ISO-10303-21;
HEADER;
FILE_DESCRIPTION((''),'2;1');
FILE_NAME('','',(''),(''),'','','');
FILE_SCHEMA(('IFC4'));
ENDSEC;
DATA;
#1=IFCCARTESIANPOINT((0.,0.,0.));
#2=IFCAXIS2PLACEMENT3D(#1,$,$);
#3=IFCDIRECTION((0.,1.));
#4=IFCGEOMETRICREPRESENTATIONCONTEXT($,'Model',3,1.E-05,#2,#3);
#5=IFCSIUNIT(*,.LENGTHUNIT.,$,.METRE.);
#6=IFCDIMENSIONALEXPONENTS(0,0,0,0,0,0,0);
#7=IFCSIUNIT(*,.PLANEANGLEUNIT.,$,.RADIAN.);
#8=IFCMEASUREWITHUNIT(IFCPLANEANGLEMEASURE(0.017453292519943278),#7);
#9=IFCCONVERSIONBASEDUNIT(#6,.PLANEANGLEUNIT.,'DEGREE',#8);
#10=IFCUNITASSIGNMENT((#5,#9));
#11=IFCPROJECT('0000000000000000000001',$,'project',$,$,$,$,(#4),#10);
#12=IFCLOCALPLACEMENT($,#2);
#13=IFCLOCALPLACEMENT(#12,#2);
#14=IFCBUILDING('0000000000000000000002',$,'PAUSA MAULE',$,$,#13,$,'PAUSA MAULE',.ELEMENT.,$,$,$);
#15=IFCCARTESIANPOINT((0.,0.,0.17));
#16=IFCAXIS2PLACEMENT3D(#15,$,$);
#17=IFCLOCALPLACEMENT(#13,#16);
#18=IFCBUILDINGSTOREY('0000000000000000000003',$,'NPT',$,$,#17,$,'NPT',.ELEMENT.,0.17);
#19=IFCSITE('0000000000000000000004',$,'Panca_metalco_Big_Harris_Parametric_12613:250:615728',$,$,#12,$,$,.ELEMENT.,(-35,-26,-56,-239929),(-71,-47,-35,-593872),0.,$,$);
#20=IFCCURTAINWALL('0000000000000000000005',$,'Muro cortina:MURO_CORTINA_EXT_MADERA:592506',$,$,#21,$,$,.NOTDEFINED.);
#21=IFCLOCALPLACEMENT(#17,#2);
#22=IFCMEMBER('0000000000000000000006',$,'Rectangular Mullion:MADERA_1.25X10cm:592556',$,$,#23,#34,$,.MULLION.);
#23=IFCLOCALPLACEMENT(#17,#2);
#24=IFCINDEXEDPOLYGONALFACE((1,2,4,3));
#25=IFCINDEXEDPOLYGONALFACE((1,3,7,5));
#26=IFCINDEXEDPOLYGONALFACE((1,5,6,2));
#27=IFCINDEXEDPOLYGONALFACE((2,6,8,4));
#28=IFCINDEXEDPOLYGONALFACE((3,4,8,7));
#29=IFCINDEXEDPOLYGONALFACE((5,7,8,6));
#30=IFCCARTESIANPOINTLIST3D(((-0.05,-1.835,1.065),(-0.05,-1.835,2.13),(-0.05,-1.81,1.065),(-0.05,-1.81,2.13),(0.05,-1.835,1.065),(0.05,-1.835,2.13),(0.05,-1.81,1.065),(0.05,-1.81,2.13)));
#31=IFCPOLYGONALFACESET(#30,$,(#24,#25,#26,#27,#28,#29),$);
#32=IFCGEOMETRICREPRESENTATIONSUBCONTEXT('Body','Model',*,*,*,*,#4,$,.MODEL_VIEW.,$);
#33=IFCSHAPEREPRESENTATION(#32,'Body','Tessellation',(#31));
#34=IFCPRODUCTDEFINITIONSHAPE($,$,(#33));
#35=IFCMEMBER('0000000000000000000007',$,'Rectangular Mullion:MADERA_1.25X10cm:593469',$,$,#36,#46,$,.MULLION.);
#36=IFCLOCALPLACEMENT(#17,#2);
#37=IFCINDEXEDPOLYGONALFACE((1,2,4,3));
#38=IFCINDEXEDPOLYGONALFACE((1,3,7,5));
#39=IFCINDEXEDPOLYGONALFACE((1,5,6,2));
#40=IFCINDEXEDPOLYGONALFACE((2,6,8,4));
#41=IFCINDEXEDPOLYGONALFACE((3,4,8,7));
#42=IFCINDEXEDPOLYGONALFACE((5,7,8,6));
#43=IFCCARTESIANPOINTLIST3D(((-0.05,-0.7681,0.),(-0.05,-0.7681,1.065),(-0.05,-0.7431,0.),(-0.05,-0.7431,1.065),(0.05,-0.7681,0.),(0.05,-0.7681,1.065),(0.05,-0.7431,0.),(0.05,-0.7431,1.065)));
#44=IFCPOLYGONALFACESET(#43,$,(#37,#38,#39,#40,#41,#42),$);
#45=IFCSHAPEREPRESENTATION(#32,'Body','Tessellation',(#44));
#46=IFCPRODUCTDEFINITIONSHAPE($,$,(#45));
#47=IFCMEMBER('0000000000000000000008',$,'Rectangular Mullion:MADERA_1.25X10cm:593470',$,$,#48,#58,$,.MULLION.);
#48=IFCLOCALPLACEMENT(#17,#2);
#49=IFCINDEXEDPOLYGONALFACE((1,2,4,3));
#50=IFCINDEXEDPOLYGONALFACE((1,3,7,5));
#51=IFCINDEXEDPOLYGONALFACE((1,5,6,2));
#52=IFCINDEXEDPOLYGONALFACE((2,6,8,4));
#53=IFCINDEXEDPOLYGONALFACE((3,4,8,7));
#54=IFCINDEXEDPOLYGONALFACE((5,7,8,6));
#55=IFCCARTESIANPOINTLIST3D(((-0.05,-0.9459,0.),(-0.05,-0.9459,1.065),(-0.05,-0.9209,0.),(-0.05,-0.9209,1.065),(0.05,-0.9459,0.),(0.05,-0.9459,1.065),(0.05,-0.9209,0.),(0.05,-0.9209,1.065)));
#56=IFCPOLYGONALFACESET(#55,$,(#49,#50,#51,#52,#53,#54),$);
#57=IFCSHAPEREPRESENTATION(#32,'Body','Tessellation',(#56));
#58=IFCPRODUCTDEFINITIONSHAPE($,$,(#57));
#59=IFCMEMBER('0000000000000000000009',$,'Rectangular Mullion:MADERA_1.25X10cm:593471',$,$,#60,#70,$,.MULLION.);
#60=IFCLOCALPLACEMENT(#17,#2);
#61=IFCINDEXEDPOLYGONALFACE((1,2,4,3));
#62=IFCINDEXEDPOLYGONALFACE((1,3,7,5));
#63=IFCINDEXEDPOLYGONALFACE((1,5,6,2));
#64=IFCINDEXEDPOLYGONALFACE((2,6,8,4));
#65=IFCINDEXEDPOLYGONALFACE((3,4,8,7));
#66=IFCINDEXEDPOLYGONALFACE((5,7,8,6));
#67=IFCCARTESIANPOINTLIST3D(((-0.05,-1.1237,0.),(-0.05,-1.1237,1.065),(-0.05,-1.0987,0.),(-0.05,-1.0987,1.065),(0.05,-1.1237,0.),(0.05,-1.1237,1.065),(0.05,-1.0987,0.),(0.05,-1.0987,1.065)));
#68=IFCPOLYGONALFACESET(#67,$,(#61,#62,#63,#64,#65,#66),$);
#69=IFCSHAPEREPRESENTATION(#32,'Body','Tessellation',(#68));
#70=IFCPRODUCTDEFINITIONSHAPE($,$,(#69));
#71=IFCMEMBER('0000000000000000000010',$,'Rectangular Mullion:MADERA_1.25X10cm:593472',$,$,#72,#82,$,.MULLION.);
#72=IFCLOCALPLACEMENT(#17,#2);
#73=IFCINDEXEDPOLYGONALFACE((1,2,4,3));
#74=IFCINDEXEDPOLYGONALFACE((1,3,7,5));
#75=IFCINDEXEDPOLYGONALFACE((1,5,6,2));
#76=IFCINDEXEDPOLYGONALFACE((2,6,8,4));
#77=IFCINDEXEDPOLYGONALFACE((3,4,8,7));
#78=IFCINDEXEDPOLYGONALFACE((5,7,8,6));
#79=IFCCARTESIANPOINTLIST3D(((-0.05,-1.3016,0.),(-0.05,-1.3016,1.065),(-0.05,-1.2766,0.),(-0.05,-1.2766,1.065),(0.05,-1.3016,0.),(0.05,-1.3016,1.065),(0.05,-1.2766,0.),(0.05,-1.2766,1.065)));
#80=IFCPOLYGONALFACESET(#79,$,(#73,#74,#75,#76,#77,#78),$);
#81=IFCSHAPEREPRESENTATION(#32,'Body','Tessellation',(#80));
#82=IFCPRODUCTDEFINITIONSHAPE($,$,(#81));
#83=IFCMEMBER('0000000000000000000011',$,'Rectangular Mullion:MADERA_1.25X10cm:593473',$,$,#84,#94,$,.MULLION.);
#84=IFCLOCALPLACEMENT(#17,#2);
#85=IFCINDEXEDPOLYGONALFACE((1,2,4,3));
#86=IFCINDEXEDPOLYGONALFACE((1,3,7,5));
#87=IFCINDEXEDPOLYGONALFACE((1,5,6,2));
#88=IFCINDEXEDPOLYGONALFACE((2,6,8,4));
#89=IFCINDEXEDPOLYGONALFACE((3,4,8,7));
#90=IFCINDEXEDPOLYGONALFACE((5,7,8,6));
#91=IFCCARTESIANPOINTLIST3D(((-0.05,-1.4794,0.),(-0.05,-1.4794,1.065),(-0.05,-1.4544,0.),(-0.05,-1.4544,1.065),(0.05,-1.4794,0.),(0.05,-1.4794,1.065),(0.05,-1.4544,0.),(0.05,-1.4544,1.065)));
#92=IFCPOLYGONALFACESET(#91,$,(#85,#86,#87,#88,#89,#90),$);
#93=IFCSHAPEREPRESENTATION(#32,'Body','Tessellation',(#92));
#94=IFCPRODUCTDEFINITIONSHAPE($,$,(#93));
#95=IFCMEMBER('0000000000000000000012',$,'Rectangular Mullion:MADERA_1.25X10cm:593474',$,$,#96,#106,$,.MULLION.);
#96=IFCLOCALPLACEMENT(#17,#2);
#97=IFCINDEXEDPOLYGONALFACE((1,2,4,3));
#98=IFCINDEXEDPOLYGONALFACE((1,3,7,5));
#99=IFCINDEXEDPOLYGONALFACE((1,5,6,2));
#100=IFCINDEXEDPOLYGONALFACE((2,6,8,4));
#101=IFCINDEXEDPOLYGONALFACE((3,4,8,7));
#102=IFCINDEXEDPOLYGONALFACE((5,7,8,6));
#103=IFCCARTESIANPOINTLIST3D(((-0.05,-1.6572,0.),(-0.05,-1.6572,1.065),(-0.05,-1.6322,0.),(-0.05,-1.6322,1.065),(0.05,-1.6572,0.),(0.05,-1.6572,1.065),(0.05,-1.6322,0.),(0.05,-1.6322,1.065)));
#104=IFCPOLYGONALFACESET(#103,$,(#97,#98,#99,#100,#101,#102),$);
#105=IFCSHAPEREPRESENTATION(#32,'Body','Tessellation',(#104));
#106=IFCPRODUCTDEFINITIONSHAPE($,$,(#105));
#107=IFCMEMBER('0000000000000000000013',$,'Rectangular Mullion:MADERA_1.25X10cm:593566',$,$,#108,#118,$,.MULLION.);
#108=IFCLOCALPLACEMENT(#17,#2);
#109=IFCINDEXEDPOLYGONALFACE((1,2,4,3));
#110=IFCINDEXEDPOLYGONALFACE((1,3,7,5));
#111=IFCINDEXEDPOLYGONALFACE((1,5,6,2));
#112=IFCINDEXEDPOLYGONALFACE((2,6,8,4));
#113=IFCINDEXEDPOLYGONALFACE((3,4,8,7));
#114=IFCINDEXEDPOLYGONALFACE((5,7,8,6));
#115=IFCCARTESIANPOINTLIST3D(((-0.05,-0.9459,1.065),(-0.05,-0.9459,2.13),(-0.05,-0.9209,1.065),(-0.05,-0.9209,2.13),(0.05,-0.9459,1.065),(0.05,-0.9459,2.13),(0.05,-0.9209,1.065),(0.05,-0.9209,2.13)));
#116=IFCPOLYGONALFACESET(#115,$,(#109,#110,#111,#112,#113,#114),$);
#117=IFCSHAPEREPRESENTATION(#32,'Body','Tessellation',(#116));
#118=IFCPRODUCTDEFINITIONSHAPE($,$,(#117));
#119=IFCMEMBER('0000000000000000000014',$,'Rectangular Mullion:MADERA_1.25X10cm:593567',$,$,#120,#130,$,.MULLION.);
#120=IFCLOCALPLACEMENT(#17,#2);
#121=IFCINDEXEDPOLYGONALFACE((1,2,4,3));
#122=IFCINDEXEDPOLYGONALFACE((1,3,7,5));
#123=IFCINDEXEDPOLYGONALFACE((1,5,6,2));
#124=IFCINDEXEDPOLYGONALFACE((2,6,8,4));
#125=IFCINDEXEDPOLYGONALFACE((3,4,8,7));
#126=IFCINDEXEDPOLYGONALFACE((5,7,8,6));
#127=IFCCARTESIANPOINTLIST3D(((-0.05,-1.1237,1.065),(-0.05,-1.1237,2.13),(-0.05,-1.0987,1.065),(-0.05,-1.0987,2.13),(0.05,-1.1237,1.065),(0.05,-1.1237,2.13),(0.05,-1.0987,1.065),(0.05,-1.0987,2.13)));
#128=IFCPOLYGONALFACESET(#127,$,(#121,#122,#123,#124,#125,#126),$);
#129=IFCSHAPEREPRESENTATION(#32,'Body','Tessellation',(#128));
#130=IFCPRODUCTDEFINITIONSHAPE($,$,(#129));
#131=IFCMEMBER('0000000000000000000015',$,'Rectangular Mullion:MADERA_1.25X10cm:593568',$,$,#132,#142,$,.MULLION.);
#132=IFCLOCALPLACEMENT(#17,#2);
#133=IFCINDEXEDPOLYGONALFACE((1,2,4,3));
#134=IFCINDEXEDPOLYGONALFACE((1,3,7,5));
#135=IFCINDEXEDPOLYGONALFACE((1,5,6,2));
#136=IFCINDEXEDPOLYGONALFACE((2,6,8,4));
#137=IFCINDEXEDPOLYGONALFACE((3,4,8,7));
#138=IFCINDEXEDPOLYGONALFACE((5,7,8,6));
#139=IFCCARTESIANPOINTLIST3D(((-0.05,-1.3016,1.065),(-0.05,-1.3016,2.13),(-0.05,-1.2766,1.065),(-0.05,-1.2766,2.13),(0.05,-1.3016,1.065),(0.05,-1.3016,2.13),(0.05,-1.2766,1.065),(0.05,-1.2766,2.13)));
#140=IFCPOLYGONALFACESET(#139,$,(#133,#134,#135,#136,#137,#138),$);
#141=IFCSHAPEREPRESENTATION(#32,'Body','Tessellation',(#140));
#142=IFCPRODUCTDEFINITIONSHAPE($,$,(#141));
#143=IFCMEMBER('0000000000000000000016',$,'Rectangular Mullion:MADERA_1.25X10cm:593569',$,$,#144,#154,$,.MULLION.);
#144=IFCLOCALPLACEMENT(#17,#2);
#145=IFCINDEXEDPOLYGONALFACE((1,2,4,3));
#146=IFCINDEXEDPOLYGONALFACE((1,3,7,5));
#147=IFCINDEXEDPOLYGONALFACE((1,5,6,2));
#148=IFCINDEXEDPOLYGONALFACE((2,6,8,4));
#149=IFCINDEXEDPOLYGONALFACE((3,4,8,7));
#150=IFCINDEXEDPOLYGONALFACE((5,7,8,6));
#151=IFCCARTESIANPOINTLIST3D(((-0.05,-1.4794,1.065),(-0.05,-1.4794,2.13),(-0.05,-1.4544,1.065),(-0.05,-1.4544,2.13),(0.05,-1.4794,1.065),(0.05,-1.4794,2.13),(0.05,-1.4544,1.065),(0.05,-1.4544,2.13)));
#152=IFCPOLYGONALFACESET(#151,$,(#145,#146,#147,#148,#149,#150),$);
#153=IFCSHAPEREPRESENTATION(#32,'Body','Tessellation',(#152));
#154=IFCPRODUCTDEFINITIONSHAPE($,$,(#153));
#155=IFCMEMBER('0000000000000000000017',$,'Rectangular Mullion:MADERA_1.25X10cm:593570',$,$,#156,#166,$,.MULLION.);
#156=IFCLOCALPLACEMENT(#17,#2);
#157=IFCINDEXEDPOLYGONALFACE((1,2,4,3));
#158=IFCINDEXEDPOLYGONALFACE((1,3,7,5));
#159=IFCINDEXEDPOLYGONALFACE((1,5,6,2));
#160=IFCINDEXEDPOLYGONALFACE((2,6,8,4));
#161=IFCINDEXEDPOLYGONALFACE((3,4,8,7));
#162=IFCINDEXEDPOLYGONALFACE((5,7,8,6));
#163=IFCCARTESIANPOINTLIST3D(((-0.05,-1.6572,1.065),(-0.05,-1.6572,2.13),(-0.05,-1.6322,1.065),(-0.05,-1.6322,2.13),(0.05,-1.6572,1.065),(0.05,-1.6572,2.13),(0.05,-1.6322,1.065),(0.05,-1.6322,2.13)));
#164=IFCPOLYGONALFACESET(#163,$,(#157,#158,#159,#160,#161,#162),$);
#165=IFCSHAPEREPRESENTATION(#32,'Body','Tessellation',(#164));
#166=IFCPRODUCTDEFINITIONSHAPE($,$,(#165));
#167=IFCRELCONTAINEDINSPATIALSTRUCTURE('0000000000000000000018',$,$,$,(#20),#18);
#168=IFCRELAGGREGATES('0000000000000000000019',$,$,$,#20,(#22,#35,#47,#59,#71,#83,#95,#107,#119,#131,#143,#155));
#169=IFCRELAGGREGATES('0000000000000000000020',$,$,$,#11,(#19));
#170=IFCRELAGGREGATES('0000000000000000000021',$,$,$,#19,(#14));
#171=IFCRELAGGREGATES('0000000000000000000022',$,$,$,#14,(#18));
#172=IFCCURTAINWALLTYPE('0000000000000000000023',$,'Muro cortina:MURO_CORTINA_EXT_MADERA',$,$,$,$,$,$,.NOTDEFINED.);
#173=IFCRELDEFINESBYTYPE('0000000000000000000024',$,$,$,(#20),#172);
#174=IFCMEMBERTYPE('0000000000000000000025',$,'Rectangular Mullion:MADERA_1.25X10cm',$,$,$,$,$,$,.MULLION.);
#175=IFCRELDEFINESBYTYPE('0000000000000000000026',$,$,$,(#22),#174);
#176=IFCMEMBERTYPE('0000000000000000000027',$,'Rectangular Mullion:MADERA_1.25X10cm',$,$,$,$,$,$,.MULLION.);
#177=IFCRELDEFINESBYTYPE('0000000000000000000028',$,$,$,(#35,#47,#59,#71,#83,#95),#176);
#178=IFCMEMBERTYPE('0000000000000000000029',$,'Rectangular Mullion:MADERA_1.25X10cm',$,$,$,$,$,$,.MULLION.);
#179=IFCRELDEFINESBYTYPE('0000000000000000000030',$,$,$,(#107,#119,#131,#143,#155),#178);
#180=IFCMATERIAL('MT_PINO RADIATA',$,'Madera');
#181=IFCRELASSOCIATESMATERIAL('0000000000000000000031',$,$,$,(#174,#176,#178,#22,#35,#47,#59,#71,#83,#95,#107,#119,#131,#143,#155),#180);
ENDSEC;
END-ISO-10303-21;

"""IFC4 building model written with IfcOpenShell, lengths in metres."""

from ifc_helpers import new_model, entity, si_unit, converted_unit, direction, frame, frame_2d, origin, origin_2d_with_axis, place, context, subcontext, project, spatial, rectangle, extrude, source, transform, mapped, material, material_profile, profile_set, profile_usage, type_object, type_shapes, element, aggregate, save


model = new_model("IFC4")

# Units and contexts
model_context = context("Model", 3, precision=1e-05, world=origin(), true_north=direction((0.0, 1.0)))
body_context = subcontext(model_context, "Body", "Model", "MODEL_VIEW")
ifc_project = project(units=[si_unit("LENGTHUNIT", "METRE"), converted_unit("PLANEANGLEUNIT", "DEGREE", entity("IfcPlaneAngleMeasure", 0.017453292519943278), si_unit("PLANEANGLEUNIT", "RADIAN"), dimensions=[0, 0, 0, 0, 0, 0, 0])], contexts=[model_context])

# Site, building, storey
site_placement = place(None, origin())
site = spatial("IfcSite", under=ifc_project, at=site_placement, Name="Panca_metalco_Big_Harris_Parametric_12613:250:615728", CompositionType="ELEMENT", RefLatitude=(-35, -26, -56, -239929), RefLongitude=(-71, -47, -35, -593872), RefElevation=0.0)
building_placement = place(site_placement, origin())
building = spatial("IfcBuilding", under=site, at=building_placement, Name="PAUSA MAULE", LongName="PAUSA MAULE", CompositionType="ELEMENT")
storey_placement = place(building_placement, frame((0.0, 0.0, 0.17)))
storey = spatial("IfcBuildingStorey", under=building, at=storey_placement, Name="NPT", LongName="NPT", CompositionType="ELEMENT", Elevation=0.17)

# Curtain wall, members
curtain_wall_type = type_object("IfcCurtainWallType", Name="Muro cortina:MURO_CORTINA_EXT_MADERA", PredefinedType="NOTDEFINED")
curtain_wall_placement = place(storey_placement, frame((0.0, 0.0, -0.17)))
curtain_wall = element("IfcCurtainWall", 1, at=curtain_wall_placement, inside=storey, type_object=curtain_wall_type, Name="Muro cortina:MURO_CORTINA_EXT_MADERA:592506", PredefinedType="NOTDEFINED")
ifc_material = material(Name="MT_PINO RADIATA", Category="Madera")
ifc_material_profile = material_profile(ifc_material, rectangle(XDim=0.025, YDim=0.1, at=frame_2d((0.0, 0.0), x_axis=(1.0, 0.0))), Name="MADERA_1.25X10cm")
ifc_profile_set = profile_set([ifc_material_profile], Name="MADERA_1.25X10cm")
ifc_profile_usage = profile_usage(ifc_profile_set)
member_type_1 = type_object("IfcMemberType", Name="Rectangular Mullion:MADERA_1.25X10cm", PredefinedType="MULLION", material=ifc_profile_set)
shared_shape_1 = source(origin(), body_context, "Body", "SweptSolid", [
    extrude(rectangle(XDim=0.025, YDim=0.1, at=origin_2d_with_axis()), frame((-0.0125, 0.0, -1.065), z_axis=(0.0, 0.0, 1.0), x_axis=(-1.0, 0.0, 0.0)), (0.0, 0.0, 1.0), 1.065),
])
type_shapes(member_type_1, [shared_shape_1])
member_1_placement = place(curtain_wall_placement, frame((0.0, -1.835, 1.235), z_axis=(0.0, 0.0, -1.0), x_axis=(0.0, -1.0, 0.0)))
member_1 = element("IfcMember", 2, at=member_1_placement, type_object=member_type_1, material=ifc_profile_usage, Name="Rectangular Mullion:MADERA_1.25X10cm:592556", PredefinedType="MULLION", context=body_context, shape_type="MappedRepresentation", body=[
    mapped(shared_shape_1, transform((0.0, 0.0, 0.0), scale=1.0)),
])
member_type_2 = type_object("IfcMemberType", Name="Rectangular Mullion:MADERA_1.25X10cm", PredefinedType="MULLION", material=ifc_profile_set)
shared_shape_2 = source(origin(), body_context, "Body", "SweptSolid", [
    extrude(rectangle(XDim=0.025, YDim=0.1, at=frame_2d((0.0, 0.0), x_axis=(1.0, 0.0))), frame((0.0, 0.0, -1.065), z_axis=(0.0, 0.0, 1.0), x_axis=(-1.0, 0.0, 0.0)), (0.0, 0.0, 1.0), 1.065),
])
type_shapes(member_type_2, [shared_shape_2])
member_2_placement = place(curtain_wall_placement, frame((0.0, -0.7556, 0.17), z_axis=(0.0, 0.0, -1.0), x_axis=(0.0, -1.0, 0.0)))
member_2 = element("IfcMember", 3, at=member_2_placement, type_object=member_type_2, material=ifc_profile_usage, Name="Rectangular Mullion:MADERA_1.25X10cm:593469", PredefinedType="MULLION", context=body_context, shape_type="MappedRepresentation", body=[
    mapped(shared_shape_2, transform((0.0, 0.0, 0.0), scale=1.0)),
])
member_3_placement = place(curtain_wall_placement, frame((0.0, -0.9334, 0.17), z_axis=(0.0, 0.0, -1.0), x_axis=(0.0, -1.0, 0.0)))
member_3 = element("IfcMember", 4, at=member_3_placement, type_object=member_type_2, material=ifc_profile_usage, Name="Rectangular Mullion:MADERA_1.25X10cm:593470", PredefinedType="MULLION", context=body_context, shape_type="MappedRepresentation", body=[
    mapped(shared_shape_2, transform((0.0, 0.0, 0.0), scale=1.0)),
])
member_4_placement = place(curtain_wall_placement, frame((0.0, -1.1112, 0.17), z_axis=(0.0, 0.0, -1.0), x_axis=(0.0, -1.0, 0.0)))
member_4 = element("IfcMember", 5, at=member_4_placement, type_object=member_type_2, material=ifc_profile_usage, Name="Rectangular Mullion:MADERA_1.25X10cm:593471", PredefinedType="MULLION", context=body_context, shape_type="MappedRepresentation", body=[
    mapped(shared_shape_2, transform((0.0, 0.0, 0.0), scale=1.0)),
])
member_5_placement = place(curtain_wall_placement, frame((0.0, -1.2891, 0.17), z_axis=(0.0, 0.0, -1.0), x_axis=(0.0, -1.0, 0.0)))
member_5 = element("IfcMember", 6, at=member_5_placement, type_object=member_type_2, material=ifc_profile_usage, Name="Rectangular Mullion:MADERA_1.25X10cm:593472", PredefinedType="MULLION", context=body_context, shape_type="MappedRepresentation", body=[
    mapped(shared_shape_2, transform((0.0, 0.0, 0.0), scale=1.0)),
])
member_6_placement = place(curtain_wall_placement, frame((0.0, -1.4669, 0.17), z_axis=(0.0, 0.0, -1.0), x_axis=(0.0, -1.0, 0.0)))
member_6 = element("IfcMember", 7, at=member_6_placement, type_object=member_type_2, material=ifc_profile_usage, Name="Rectangular Mullion:MADERA_1.25X10cm:593473", PredefinedType="MULLION", context=body_context, shape_type="MappedRepresentation", body=[
    mapped(shared_shape_2, transform((0.0, 0.0, 0.0), scale=1.0)),
])
member_7_placement = place(curtain_wall_placement, frame((0.0, -1.6447, 0.17), z_axis=(0.0, 0.0, -1.0), x_axis=(0.0, -1.0, 0.0)))
member_7 = element("IfcMember", 8, at=member_7_placement, type_object=member_type_2, material=ifc_profile_usage, Name="Rectangular Mullion:MADERA_1.25X10cm:593474", PredefinedType="MULLION", context=body_context, shape_type="MappedRepresentation", body=[
    mapped(shared_shape_2, transform((0.0, 0.0, 0.0), scale=1.0)),
])
member_type_3 = type_object("IfcMemberType", Name="Rectangular Mullion:MADERA_1.25X10cm", PredefinedType="MULLION", material=ifc_profile_set)
shared_shape_3 = source(origin(), body_context, "Body", "SweptSolid", [
    extrude(rectangle(XDim=0.025, YDim=0.1, at=frame_2d((0.0, 0.0), x_axis=(1.0, 0.0))), frame((0.0, 0.0, -1.065), z_axis=(0.0, 0.0, 1.0), x_axis=(-1.0, 0.0, 0.0)), (0.0, 0.0, 1.0), 1.065),
])
type_shapes(member_type_3, [shared_shape_3])
member_8_placement = place(curtain_wall_placement, frame((0.0, -0.9334, 1.235), z_axis=(0.0, 0.0, -1.0), x_axis=(0.0, -1.0, 0.0)))
member_8 = element("IfcMember", 9, at=member_8_placement, type_object=member_type_3, material=ifc_profile_usage, Name="Rectangular Mullion:MADERA_1.25X10cm:593566", PredefinedType="MULLION", context=body_context, shape_type="MappedRepresentation", body=[
    mapped(shared_shape_3, transform((0.0, 0.0, 0.0), scale=1.0)),
])
member_9_placement = place(curtain_wall_placement, frame((0.0, -1.1112, 1.235), z_axis=(0.0, 0.0, -1.0), x_axis=(0.0, -1.0, 0.0)))
member_9 = element("IfcMember", 10, at=member_9_placement, type_object=member_type_3, material=ifc_profile_usage, Name="Rectangular Mullion:MADERA_1.25X10cm:593567", PredefinedType="MULLION", context=body_context, shape_type="MappedRepresentation", body=[
    mapped(shared_shape_3, transform((0.0, 0.0, 0.0), scale=1.0)),
])
member_10_placement = place(curtain_wall_placement, frame((0.0, -1.2891, 1.235), z_axis=(0.0, 0.0, -1.0), x_axis=(0.0, -1.0, 0.0)))
member_10 = element("IfcMember", 11, at=member_10_placement, type_object=member_type_3, material=ifc_profile_usage, Name="Rectangular Mullion:MADERA_1.25X10cm:593568", PredefinedType="MULLION", context=body_context, shape_type="MappedRepresentation", body=[
    mapped(shared_shape_3, transform((0.0, 0.0, 0.0), scale=1.0)),
])
member_11_placement = place(curtain_wall_placement, frame((0.0, -1.4669, 1.235), z_axis=(0.0, 0.0, -1.0), x_axis=(0.0, -1.0, 0.0)))
member_11 = element("IfcMember", 12, at=member_11_placement, type_object=member_type_3, material=ifc_profile_usage, Name="Rectangular Mullion:MADERA_1.25X10cm:593569", PredefinedType="MULLION", context=body_context, shape_type="MappedRepresentation", body=[
    mapped(shared_shape_3, transform((0.0, 0.0, 0.0), scale=1.0)),
])
member_12_placement = place(curtain_wall_placement, frame((0.0, -1.6447, 1.235), z_axis=(0.0, 0.0, -1.0), x_axis=(0.0, -1.0, 0.0)))
member_12 = element("IfcMember", 13, at=member_12_placement, type_object=member_type_3, material=ifc_profile_usage, Name="Rectangular Mullion:MADERA_1.25X10cm:593570", PredefinedType="MULLION", context=body_context, shape_type="MappedRepresentation", body=[
    mapped(shared_shape_3, transform((0.0, 0.0, 0.0), scale=1.0)),
])
aggregate(curtain_wall, [member_1, member_2, member_3, member_4, member_5, member_6, member_7, member_8, member_9, member_10, member_11, member_12])

save(model, "model.ifc")
